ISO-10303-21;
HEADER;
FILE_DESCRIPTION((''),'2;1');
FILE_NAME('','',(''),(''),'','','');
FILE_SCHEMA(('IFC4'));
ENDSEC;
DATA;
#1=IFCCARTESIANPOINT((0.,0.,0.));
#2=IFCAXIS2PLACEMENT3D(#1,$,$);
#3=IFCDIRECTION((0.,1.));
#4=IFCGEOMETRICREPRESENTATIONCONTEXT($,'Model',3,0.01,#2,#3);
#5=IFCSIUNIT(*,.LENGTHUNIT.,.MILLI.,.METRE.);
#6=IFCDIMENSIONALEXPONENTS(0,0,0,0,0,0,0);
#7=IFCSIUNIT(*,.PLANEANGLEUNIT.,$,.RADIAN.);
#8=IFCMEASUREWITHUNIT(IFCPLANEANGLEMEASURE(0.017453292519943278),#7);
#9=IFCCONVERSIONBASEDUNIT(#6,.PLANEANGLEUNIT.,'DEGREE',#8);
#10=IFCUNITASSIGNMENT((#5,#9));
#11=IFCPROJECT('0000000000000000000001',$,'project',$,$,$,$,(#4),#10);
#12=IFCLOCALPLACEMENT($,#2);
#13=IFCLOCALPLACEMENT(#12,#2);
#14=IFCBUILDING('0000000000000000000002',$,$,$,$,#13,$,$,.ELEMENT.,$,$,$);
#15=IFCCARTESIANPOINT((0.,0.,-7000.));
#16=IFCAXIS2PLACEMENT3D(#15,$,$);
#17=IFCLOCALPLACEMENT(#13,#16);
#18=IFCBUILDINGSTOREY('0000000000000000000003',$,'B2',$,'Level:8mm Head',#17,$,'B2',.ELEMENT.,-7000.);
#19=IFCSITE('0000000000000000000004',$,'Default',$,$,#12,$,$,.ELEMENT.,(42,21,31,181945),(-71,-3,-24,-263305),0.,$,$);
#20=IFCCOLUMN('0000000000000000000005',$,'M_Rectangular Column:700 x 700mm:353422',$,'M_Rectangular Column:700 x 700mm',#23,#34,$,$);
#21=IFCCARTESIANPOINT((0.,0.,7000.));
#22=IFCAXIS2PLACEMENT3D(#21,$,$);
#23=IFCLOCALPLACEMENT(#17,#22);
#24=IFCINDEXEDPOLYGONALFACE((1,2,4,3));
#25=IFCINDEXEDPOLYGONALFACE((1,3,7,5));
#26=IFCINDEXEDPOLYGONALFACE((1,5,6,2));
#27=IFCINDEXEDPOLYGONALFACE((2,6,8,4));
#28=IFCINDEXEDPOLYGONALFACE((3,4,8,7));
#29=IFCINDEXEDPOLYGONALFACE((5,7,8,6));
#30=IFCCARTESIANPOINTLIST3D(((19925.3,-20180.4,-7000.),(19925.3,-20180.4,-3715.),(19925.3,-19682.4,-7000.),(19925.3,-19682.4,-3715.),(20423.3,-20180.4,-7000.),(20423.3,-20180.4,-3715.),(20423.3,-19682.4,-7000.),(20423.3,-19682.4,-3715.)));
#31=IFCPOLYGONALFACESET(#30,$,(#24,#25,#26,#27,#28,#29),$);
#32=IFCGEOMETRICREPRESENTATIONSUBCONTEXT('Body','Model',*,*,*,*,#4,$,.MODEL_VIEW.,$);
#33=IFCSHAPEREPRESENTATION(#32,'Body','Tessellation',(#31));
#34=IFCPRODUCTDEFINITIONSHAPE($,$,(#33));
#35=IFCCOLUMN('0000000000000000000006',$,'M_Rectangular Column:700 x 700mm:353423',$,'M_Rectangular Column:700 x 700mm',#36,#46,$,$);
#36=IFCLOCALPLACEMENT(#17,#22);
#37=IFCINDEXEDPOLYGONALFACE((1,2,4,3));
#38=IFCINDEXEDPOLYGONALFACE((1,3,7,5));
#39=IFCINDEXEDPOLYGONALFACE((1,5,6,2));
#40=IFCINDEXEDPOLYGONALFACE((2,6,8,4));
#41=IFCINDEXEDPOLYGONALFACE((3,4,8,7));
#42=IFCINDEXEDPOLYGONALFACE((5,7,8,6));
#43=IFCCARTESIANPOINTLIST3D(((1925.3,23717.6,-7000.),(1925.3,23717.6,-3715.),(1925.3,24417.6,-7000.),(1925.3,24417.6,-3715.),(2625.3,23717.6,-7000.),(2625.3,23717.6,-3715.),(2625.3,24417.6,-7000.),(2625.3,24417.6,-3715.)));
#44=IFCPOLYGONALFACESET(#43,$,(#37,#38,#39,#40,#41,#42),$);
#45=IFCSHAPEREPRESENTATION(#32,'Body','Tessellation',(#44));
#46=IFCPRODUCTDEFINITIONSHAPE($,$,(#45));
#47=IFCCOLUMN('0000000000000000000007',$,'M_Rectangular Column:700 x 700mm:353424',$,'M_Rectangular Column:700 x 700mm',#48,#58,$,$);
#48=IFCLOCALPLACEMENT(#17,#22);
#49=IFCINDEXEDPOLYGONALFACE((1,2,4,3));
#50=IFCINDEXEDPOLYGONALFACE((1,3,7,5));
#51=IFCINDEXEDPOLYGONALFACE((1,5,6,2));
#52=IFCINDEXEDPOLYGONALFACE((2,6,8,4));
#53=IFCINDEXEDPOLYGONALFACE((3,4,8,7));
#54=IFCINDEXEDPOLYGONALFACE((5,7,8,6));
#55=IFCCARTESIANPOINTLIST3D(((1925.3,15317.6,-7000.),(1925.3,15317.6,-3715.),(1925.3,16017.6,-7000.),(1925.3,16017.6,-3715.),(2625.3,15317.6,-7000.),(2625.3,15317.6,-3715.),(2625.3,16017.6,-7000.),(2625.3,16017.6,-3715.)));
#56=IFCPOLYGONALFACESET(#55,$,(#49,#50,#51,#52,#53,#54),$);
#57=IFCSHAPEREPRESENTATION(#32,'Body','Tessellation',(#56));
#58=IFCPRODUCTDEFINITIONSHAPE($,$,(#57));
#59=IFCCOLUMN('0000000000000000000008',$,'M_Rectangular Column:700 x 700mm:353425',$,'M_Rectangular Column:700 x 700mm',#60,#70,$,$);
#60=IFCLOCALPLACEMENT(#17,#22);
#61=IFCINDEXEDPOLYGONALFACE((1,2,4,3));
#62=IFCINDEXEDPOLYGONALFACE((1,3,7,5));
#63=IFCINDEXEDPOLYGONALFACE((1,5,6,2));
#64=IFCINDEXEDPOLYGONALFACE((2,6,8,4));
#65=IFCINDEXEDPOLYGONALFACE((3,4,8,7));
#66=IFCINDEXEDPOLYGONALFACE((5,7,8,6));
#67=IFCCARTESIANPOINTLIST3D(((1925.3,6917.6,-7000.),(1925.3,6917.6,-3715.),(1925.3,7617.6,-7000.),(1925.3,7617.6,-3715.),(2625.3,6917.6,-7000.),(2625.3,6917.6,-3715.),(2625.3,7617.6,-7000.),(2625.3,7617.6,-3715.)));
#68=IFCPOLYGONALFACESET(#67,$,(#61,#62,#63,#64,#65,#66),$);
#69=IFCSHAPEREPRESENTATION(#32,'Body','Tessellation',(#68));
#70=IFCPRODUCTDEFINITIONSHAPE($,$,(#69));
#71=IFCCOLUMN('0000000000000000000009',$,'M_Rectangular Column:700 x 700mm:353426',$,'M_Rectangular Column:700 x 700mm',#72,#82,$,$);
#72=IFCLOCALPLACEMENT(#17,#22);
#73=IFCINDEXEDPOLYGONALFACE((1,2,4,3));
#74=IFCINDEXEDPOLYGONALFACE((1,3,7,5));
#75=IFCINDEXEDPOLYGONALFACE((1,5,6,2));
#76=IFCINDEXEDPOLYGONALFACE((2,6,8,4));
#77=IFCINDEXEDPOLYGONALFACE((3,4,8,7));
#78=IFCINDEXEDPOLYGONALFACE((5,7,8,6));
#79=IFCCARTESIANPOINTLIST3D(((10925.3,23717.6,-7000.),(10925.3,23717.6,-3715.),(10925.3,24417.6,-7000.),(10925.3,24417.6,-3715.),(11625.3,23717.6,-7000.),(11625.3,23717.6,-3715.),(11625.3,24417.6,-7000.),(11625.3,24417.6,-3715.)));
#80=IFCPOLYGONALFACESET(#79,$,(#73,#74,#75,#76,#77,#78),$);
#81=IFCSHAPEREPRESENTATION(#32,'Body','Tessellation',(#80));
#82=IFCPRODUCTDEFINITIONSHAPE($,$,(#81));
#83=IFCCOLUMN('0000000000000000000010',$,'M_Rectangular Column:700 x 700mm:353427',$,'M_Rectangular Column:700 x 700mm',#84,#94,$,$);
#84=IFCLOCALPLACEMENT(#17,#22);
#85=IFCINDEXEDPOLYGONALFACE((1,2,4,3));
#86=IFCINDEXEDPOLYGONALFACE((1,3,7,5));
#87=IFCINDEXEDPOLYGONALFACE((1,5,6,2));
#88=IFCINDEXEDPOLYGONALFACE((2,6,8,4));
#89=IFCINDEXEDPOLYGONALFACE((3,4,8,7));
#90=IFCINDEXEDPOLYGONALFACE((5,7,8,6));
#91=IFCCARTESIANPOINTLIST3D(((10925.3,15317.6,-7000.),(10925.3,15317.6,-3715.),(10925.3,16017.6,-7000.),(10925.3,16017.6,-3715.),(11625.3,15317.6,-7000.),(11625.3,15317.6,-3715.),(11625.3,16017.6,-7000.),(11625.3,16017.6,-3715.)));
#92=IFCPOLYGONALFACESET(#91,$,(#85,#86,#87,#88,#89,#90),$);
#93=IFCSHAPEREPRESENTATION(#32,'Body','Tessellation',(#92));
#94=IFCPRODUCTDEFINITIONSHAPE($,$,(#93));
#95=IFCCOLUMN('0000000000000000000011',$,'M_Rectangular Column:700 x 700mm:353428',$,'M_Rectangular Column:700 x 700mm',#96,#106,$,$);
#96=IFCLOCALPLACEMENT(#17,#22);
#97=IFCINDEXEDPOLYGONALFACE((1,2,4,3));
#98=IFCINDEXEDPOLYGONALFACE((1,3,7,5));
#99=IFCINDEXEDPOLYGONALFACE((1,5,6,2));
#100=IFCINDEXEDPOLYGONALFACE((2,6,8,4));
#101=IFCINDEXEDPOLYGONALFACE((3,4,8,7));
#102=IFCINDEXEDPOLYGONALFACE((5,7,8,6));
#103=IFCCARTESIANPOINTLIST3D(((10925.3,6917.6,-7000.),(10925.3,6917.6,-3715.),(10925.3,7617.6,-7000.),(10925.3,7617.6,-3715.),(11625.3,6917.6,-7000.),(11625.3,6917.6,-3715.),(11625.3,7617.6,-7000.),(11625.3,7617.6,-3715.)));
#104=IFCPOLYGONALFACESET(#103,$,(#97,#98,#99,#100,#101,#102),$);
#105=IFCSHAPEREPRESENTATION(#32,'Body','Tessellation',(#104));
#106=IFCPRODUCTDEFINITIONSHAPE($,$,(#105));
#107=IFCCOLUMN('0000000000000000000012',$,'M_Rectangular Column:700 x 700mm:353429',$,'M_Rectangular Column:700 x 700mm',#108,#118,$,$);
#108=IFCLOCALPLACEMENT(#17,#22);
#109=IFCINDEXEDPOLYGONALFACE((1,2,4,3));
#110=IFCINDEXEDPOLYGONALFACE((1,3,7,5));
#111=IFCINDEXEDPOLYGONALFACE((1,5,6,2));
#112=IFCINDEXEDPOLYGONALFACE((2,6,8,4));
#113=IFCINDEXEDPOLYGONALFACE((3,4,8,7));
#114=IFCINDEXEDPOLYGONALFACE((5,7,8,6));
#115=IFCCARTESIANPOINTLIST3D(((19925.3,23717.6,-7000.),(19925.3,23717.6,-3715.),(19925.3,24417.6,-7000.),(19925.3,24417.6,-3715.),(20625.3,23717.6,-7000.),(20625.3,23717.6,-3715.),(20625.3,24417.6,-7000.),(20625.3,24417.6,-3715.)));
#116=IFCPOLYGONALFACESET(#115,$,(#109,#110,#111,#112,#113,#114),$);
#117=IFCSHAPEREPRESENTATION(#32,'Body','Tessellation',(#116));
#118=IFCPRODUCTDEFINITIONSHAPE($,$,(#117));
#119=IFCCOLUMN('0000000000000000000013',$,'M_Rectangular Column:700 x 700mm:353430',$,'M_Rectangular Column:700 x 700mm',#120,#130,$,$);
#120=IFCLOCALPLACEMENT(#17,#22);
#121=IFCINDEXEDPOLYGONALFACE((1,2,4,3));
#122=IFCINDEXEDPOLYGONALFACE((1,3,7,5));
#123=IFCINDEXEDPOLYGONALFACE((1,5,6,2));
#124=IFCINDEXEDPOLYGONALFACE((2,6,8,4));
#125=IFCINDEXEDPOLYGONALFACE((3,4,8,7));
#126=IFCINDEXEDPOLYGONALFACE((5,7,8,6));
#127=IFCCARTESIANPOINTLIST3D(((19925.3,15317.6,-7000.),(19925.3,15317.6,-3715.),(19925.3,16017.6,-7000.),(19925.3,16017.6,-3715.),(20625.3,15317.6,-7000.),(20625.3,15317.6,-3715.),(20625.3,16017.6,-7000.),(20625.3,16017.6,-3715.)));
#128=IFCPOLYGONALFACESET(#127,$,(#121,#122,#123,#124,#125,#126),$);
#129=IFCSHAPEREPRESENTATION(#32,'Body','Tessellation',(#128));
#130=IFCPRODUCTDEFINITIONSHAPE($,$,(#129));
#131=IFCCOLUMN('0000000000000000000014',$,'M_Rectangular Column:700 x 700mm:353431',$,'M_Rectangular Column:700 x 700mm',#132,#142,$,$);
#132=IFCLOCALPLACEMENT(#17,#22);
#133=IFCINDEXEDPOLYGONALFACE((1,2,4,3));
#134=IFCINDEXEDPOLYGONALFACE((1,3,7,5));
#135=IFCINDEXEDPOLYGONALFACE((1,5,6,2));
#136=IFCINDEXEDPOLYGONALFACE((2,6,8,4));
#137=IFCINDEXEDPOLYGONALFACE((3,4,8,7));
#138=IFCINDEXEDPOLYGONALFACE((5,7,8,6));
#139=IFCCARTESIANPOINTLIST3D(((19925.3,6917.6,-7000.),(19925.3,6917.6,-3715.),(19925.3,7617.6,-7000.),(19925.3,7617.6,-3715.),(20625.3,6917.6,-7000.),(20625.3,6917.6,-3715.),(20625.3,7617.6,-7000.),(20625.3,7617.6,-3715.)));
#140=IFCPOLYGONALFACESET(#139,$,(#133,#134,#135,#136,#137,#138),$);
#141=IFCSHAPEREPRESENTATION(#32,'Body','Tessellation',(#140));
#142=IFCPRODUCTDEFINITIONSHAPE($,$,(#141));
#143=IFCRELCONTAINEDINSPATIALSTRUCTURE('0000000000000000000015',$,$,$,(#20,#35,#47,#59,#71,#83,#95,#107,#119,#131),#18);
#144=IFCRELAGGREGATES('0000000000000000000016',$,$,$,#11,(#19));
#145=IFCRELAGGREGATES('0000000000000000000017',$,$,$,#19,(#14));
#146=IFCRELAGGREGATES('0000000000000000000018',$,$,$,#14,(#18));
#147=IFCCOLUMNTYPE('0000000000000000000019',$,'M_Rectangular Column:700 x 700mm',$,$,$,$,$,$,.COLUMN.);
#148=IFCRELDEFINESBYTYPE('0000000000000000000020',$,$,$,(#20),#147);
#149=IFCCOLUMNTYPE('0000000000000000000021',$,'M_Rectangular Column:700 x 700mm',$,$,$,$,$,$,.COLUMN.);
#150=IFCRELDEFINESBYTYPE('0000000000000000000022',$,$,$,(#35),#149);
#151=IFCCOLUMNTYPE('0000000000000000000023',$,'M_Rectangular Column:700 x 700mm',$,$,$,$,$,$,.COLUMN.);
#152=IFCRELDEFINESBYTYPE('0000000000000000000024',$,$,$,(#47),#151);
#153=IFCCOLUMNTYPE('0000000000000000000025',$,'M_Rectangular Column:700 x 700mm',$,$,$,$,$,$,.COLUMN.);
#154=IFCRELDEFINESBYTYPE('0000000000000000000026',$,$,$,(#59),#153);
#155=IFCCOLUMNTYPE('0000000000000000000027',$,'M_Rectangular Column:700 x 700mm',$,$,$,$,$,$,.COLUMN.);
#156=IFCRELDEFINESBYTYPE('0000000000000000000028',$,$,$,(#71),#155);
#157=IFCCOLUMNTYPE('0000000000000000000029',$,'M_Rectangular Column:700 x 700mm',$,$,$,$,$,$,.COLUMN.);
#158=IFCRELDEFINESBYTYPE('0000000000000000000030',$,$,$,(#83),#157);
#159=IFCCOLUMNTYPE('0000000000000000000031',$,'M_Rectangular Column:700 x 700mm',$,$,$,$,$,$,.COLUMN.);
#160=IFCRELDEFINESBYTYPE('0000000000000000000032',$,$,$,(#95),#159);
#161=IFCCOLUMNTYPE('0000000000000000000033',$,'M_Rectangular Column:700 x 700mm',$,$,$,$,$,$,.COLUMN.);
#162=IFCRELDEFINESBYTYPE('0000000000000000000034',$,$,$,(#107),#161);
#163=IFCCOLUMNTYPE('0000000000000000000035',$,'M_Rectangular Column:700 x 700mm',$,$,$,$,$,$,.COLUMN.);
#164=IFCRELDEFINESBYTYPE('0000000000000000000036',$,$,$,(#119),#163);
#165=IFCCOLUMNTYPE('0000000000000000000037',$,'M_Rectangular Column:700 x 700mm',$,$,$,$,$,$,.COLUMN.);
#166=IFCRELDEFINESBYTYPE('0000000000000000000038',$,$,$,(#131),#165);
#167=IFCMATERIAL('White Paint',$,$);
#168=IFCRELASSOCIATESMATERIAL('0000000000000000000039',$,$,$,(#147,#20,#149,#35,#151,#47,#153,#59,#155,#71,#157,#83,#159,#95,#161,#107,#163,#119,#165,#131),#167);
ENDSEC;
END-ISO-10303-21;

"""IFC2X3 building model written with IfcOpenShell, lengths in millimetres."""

from ifc_helpers import new_model, entity, si_unit, converted_unit, direction, frame, frame_2d, origin, origin_2d_with_axis, place, context, subcontext, project, spatial, rectangle, extrude, source, transform, mapped, material, type_object, type_shapes, element, save


model = new_model("IFC2X3")

# Units and contexts
model_context = context("Model", 3, precision=0.01, world=origin(), true_north=direction((0.0, 1.0)))
body_context = subcontext(model_context, "Body", "Model", "MODEL_VIEW")
ifc_project = project(units=[si_unit("LENGTHUNIT", "METRE", prefix="MILLI"), converted_unit("PLANEANGLEUNIT", "DEGREE", entity("IfcPlaneAngleMeasure", 0.017453292519943278), si_unit("PLANEANGLEUNIT", "RADIAN"), dimensions=[0, 0, 0, 0, 0, 0, 0])], contexts=[model_context])

# Site, building, storey
site_placement = place(None, origin())
site = spatial("IfcSite", under=ifc_project, at=site_placement, Name="Default", CompositionType="ELEMENT", RefLatitude=(42, 21, 31, 181945), RefLongitude=(-71, -3, -24, -263305), RefElevation=0.0)
building_placement = place(site_placement, origin())
building = spatial("IfcBuilding", under=site, at=building_placement, CompositionType="ELEMENT")
storey_placement = place(building_placement, frame((0.0, 0.0, -7000.0)))
storey = spatial("IfcBuildingStorey", under=building, at=storey_placement, Name="B2", ObjectType="Level:8mm Head", LongName="B2", CompositionType="ELEMENT", Elevation=-7000.0)

# Columns
ifc_material_1 = material(Name="White Paint")
column_type_1 = type_object("IfcColumnType", Name="M_Rectangular Column:700 x 700mm", PredefinedType="COLUMN", material=ifc_material_1)
shared_shape_1 = source(origin(), body_context, "Body", "SweptSolid", [
    extrude(rectangle(XDim=498.0, YDim=498.0, at=frame_2d((0.0, 0.0), x_axis=(1.0, 0.0))), frame((20174.3, -19931.4, -7000.0)), (0.0, 0.0, 1.0), 3285.0),
])
type_shapes(column_type_1, [shared_shape_1])
column_1_placement = place(storey_placement, frame((0.0, 0.0, 7000.0)))
element("IfcColumn", 1, at=column_1_placement, inside=storey, type_object=column_type_1, material=ifc_material_1, Name="M_Rectangular Column:700 x 700mm:353422", ObjectType="M_Rectangular Column:700 x 700mm", context=body_context, shape_type="MappedRepresentation", body=[
    mapped(shared_shape_1, transform((0.0, 0.0, 0.0), scale=1.0)),
])
column_type_2 = type_object("IfcColumnType", Name="M_Rectangular Column:700 x 700mm", PredefinedType="COLUMN", material=ifc_material_1)
shared_shape_2 = source(origin(), body_context, "Body", "SweptSolid", [
    extrude(rectangle(XDim=700.0, YDim=700.0, at=frame_2d((0.0, 0.0), x_axis=(1.0, 0.0))), frame((2275.3, 24067.6, -7000.0), z_axis=(0.0, 0.0, 1.0), x_axis=(-1.0, 0.0, 0.0)), (0.0, 0.0, 1.0), 3285.0),
])
type_shapes(column_type_2, [shared_shape_2])
column_2_placement = place(storey_placement, frame((0.0, 0.0, 7000.0)))
element("IfcColumn", 2, at=column_2_placement, inside=storey, type_object=column_type_2, material=ifc_material_1, Name="M_Rectangular Column:700 x 700mm:353423", ObjectType="M_Rectangular Column:700 x 700mm", context=body_context, shape_type="MappedRepresentation", body=[
    mapped(shared_shape_2, transform((0.0, 0.0, 0.0), scale=1.0)),
])
column_type_3 = type_object("IfcColumnType", Name="M_Rectangular Column:700 x 700mm", PredefinedType="COLUMN", material=ifc_material_1)
shared_shape_3 = source(origin(), body_context, "Body", "SweptSolid", [
    extrude(rectangle(XDim=700.0, YDim=700.0, at=frame_2d((0.0, 0.0), x_axis=(1.0, 0.0))), frame((2275.3, 15667.6, -7000.0), z_axis=(0.0, 0.0, 1.0), x_axis=(-1.0, 0.0, 0.0)), (0.0, 0.0, 1.0), 3285.0),
])
type_shapes(column_type_3, [shared_shape_3])
column_3_placement = place(storey_placement, frame((0.0, 0.0, 7000.0)))
element("IfcColumn", 3, at=column_3_placement, inside=storey, type_object=column_type_3, material=ifc_material_1, Name="M_Rectangular Column:700 x 700mm:353424", ObjectType="M_Rectangular Column:700 x 700mm", context=body_context, shape_type="MappedRepresentation", body=[
    mapped(shared_shape_3, transform((0.0, 0.0, 0.0), scale=1.0)),
])
column_type_4 = type_object("IfcColumnType", Name="M_Rectangular Column:700 x 700mm", PredefinedType="COLUMN", material=ifc_material_1)
shared_shape_4 = source(origin(), body_context, "Body", "SweptSolid", [
    extrude(rectangle(XDim=700.0, YDim=700.0, at=frame_2d((0.0, 0.0), x_axis=(1.0, 0.0))), frame((2275.3, 7267.6, -7000.0), z_axis=(0.0, 0.0, 1.0), x_axis=(-1.0, 0.0, 0.0)), (0.0, 0.0, 1.0), 3285.0),
])
type_shapes(column_type_4, [shared_shape_4])
column_4_placement = place(storey_placement, frame((0.0, 0.0, 7000.0)))
element("IfcColumn", 4, at=column_4_placement, inside=storey, type_object=column_type_4, material=ifc_material_1, Name="M_Rectangular Column:700 x 700mm:353425", ObjectType="M_Rectangular Column:700 x 700mm", context=body_context, shape_type="MappedRepresentation", body=[
    mapped(shared_shape_4, transform((0.0, 0.0, 0.0), scale=1.0)),
])
column_type_5 = type_object("IfcColumnType", Name="M_Rectangular Column:700 x 700mm", PredefinedType="COLUMN", material=ifc_material_1)
shared_shape_5 = source(origin(), body_context, "Body", "SweptSolid", [
    extrude(rectangle(XDim=700.0, YDim=700.0, at=origin_2d_with_axis()), frame((11275.3, 24067.6, -7000.0), z_axis=(0.0, 0.0, 1.0), x_axis=(-1.0, 0.0, 0.0)), (0.0, 0.0, 1.0), 3285.0),
])
type_shapes(column_type_5, [shared_shape_5])
column_5_placement = place(storey_placement, frame((0.0, 0.0, 7000.0)))
element("IfcColumn", 5, at=column_5_placement, inside=storey, type_object=column_type_5, material=ifc_material_1, Name="M_Rectangular Column:700 x 700mm:353426", ObjectType="M_Rectangular Column:700 x 700mm", context=body_context, shape_type="MappedRepresentation", body=[
    mapped(shared_shape_5, transform((0.0, 0.0, 0.0), scale=1.0)),
])
column_type_6 = type_object("IfcColumnType", Name="M_Rectangular Column:700 x 700mm", PredefinedType="COLUMN", material=ifc_material_1)
shared_shape_6 = source(origin(), body_context, "Body", "SweptSolid", [
    extrude(rectangle(XDim=700.0, YDim=700.0, at=frame_2d((0.0, 0.0), x_axis=(1.0, 0.0))), frame((11275.3, 15667.6, -7000.0), z_axis=(0.0, 0.0, 1.0), x_axis=(-1.0, 0.0, 0.0)), (0.0, 0.0, 1.0), 3285.0),
])
type_shapes(column_type_6, [shared_shape_6])
column_6_placement = place(storey_placement, frame((0.0, 0.0, 7000.0)))
element("IfcColumn", 6, at=column_6_placement, inside=storey, type_object=column_type_6, material=ifc_material_1, Name="M_Rectangular Column:700 x 700mm:353427", ObjectType="M_Rectangular Column:700 x 700mm", context=body_context, shape_type="MappedRepresentation", body=[
    mapped(shared_shape_6, transform((0.0, 0.0, 0.0), scale=1.0)),
])
column_type_7 = type_object("IfcColumnType", Name="M_Rectangular Column:700 x 700mm", PredefinedType="COLUMN", material=ifc_material_1)
shared_shape_7 = source(origin(), body_context, "Body", "SweptSolid", [
    extrude(rectangle(XDim=700.0, YDim=700.0, at=frame_2d((0.0, 0.0), x_axis=(1.0, 0.0))), frame((11275.3, 7267.6, -7000.0), z_axis=(0.0, 0.0, 1.0), x_axis=(-1.0, 0.0, 0.0)), (0.0, 0.0, 1.0), 3285.0),
])
type_shapes(column_type_7, [shared_shape_7])
column_7_placement = place(storey_placement, frame((0.0, 0.0, 7000.0)))
element("IfcColumn", 7, at=column_7_placement, inside=storey, type_object=column_type_7, material=ifc_material_1, Name="M_Rectangular Column:700 x 700mm:353428", ObjectType="M_Rectangular Column:700 x 700mm", context=body_context, shape_type="MappedRepresentation", body=[
    mapped(shared_shape_7, transform((0.0, 0.0, 0.0), scale=1.0)),
])
column_type_8 = type_object("IfcColumnType", Name="M_Rectangular Column:700 x 700mm", PredefinedType="COLUMN", material=ifc_material_1)
shared_shape_8 = source(origin(), body_context, "Body", "SweptSolid", [
    extrude(rectangle(XDim=700.0, YDim=700.0, at=frame_2d((0.0, 0.0), x_axis=(1.0, 0.0))), frame((20275.3, 24067.6, -7000.0), z_axis=(0.0, 0.0, 1.0), x_axis=(-1.0, 0.0, 0.0)), (0.0, 0.0, 1.0), 3285.0),
])
type_shapes(column_type_8, [shared_shape_8])
column_8_placement = place(storey_placement, frame((0.0, 0.0, 7000.0)))
element("IfcColumn", 8, at=column_8_placement, inside=storey, type_object=column_type_8, material=ifc_material_1, Name="M_Rectangular Column:700 x 700mm:353429", ObjectType="M_Rectangular Column:700 x 700mm", context=body_context, shape_type="MappedRepresentation", body=[
    mapped(shared_shape_8, transform((0.0, 0.0, 0.0), scale=1.0)),
])
column_type_9 = type_object("IfcColumnType", Name="M_Rectangular Column:700 x 700mm", PredefinedType="COLUMN", material=ifc_material_1)
shared_shape_9 = source(origin(), body_context, "Body", "SweptSolid", [
    extrude(rectangle(XDim=700.0, YDim=700.0, at=frame_2d((0.0, 0.0), x_axis=(1.0, 0.0))), frame((20275.3, 15667.6, -7000.0), z_axis=(0.0, 0.0, 1.0), x_axis=(-1.0, 0.0, 0.0)), (0.0, 0.0, 1.0), 3285.0),
])
type_shapes(column_type_9, [shared_shape_9])
column_9_placement = place(storey_placement, frame((0.0, 0.0, 7000.0)))
element("IfcColumn", 9, at=column_9_placement, inside=storey, type_object=column_type_9, material=ifc_material_1, Name="M_Rectangular Column:700 x 700mm:353430", ObjectType="M_Rectangular Column:700 x 700mm", context=body_context, shape_type="MappedRepresentation", body=[
    mapped(shared_shape_9, transform((0.0, 0.0, 0.0), scale=1.0)),
])
column_type_10 = type_object("IfcColumnType", Name="M_Rectangular Column:700 x 700mm", PredefinedType="COLUMN", material=ifc_material_1)
shared_shape_10 = source(origin(), body_context, "Body", "SweptSolid", [
    extrude(rectangle(XDim=700.0, YDim=700.0, at=frame_2d((0.0, 0.0), x_axis=(1.0, 0.0))), frame((20275.3, 7267.6, -7000.0), z_axis=(0.0, 0.0, 1.0), x_axis=(-1.0, 0.0, 0.0)), (0.0, 0.0, 1.0), 3285.0),
])
type_shapes(column_type_10, [shared_shape_10])
column_10_placement = place(storey_placement, frame((0.0, 0.0, 7000.0)))
element("IfcColumn", 10, at=column_10_placement, inside=storey, type_object=column_type_10, material=ifc_material_1, Name="M_Rectangular Column:700 x 700mm:353431", ObjectType="M_Rectangular Column:700 x 700mm", context=body_context, shape_type="MappedRepresentation", body=[
    mapped(shared_shape_10, transform((0.0, 0.0, 0.0), scale=1.0)),
])

save(model, "model.ifc")
